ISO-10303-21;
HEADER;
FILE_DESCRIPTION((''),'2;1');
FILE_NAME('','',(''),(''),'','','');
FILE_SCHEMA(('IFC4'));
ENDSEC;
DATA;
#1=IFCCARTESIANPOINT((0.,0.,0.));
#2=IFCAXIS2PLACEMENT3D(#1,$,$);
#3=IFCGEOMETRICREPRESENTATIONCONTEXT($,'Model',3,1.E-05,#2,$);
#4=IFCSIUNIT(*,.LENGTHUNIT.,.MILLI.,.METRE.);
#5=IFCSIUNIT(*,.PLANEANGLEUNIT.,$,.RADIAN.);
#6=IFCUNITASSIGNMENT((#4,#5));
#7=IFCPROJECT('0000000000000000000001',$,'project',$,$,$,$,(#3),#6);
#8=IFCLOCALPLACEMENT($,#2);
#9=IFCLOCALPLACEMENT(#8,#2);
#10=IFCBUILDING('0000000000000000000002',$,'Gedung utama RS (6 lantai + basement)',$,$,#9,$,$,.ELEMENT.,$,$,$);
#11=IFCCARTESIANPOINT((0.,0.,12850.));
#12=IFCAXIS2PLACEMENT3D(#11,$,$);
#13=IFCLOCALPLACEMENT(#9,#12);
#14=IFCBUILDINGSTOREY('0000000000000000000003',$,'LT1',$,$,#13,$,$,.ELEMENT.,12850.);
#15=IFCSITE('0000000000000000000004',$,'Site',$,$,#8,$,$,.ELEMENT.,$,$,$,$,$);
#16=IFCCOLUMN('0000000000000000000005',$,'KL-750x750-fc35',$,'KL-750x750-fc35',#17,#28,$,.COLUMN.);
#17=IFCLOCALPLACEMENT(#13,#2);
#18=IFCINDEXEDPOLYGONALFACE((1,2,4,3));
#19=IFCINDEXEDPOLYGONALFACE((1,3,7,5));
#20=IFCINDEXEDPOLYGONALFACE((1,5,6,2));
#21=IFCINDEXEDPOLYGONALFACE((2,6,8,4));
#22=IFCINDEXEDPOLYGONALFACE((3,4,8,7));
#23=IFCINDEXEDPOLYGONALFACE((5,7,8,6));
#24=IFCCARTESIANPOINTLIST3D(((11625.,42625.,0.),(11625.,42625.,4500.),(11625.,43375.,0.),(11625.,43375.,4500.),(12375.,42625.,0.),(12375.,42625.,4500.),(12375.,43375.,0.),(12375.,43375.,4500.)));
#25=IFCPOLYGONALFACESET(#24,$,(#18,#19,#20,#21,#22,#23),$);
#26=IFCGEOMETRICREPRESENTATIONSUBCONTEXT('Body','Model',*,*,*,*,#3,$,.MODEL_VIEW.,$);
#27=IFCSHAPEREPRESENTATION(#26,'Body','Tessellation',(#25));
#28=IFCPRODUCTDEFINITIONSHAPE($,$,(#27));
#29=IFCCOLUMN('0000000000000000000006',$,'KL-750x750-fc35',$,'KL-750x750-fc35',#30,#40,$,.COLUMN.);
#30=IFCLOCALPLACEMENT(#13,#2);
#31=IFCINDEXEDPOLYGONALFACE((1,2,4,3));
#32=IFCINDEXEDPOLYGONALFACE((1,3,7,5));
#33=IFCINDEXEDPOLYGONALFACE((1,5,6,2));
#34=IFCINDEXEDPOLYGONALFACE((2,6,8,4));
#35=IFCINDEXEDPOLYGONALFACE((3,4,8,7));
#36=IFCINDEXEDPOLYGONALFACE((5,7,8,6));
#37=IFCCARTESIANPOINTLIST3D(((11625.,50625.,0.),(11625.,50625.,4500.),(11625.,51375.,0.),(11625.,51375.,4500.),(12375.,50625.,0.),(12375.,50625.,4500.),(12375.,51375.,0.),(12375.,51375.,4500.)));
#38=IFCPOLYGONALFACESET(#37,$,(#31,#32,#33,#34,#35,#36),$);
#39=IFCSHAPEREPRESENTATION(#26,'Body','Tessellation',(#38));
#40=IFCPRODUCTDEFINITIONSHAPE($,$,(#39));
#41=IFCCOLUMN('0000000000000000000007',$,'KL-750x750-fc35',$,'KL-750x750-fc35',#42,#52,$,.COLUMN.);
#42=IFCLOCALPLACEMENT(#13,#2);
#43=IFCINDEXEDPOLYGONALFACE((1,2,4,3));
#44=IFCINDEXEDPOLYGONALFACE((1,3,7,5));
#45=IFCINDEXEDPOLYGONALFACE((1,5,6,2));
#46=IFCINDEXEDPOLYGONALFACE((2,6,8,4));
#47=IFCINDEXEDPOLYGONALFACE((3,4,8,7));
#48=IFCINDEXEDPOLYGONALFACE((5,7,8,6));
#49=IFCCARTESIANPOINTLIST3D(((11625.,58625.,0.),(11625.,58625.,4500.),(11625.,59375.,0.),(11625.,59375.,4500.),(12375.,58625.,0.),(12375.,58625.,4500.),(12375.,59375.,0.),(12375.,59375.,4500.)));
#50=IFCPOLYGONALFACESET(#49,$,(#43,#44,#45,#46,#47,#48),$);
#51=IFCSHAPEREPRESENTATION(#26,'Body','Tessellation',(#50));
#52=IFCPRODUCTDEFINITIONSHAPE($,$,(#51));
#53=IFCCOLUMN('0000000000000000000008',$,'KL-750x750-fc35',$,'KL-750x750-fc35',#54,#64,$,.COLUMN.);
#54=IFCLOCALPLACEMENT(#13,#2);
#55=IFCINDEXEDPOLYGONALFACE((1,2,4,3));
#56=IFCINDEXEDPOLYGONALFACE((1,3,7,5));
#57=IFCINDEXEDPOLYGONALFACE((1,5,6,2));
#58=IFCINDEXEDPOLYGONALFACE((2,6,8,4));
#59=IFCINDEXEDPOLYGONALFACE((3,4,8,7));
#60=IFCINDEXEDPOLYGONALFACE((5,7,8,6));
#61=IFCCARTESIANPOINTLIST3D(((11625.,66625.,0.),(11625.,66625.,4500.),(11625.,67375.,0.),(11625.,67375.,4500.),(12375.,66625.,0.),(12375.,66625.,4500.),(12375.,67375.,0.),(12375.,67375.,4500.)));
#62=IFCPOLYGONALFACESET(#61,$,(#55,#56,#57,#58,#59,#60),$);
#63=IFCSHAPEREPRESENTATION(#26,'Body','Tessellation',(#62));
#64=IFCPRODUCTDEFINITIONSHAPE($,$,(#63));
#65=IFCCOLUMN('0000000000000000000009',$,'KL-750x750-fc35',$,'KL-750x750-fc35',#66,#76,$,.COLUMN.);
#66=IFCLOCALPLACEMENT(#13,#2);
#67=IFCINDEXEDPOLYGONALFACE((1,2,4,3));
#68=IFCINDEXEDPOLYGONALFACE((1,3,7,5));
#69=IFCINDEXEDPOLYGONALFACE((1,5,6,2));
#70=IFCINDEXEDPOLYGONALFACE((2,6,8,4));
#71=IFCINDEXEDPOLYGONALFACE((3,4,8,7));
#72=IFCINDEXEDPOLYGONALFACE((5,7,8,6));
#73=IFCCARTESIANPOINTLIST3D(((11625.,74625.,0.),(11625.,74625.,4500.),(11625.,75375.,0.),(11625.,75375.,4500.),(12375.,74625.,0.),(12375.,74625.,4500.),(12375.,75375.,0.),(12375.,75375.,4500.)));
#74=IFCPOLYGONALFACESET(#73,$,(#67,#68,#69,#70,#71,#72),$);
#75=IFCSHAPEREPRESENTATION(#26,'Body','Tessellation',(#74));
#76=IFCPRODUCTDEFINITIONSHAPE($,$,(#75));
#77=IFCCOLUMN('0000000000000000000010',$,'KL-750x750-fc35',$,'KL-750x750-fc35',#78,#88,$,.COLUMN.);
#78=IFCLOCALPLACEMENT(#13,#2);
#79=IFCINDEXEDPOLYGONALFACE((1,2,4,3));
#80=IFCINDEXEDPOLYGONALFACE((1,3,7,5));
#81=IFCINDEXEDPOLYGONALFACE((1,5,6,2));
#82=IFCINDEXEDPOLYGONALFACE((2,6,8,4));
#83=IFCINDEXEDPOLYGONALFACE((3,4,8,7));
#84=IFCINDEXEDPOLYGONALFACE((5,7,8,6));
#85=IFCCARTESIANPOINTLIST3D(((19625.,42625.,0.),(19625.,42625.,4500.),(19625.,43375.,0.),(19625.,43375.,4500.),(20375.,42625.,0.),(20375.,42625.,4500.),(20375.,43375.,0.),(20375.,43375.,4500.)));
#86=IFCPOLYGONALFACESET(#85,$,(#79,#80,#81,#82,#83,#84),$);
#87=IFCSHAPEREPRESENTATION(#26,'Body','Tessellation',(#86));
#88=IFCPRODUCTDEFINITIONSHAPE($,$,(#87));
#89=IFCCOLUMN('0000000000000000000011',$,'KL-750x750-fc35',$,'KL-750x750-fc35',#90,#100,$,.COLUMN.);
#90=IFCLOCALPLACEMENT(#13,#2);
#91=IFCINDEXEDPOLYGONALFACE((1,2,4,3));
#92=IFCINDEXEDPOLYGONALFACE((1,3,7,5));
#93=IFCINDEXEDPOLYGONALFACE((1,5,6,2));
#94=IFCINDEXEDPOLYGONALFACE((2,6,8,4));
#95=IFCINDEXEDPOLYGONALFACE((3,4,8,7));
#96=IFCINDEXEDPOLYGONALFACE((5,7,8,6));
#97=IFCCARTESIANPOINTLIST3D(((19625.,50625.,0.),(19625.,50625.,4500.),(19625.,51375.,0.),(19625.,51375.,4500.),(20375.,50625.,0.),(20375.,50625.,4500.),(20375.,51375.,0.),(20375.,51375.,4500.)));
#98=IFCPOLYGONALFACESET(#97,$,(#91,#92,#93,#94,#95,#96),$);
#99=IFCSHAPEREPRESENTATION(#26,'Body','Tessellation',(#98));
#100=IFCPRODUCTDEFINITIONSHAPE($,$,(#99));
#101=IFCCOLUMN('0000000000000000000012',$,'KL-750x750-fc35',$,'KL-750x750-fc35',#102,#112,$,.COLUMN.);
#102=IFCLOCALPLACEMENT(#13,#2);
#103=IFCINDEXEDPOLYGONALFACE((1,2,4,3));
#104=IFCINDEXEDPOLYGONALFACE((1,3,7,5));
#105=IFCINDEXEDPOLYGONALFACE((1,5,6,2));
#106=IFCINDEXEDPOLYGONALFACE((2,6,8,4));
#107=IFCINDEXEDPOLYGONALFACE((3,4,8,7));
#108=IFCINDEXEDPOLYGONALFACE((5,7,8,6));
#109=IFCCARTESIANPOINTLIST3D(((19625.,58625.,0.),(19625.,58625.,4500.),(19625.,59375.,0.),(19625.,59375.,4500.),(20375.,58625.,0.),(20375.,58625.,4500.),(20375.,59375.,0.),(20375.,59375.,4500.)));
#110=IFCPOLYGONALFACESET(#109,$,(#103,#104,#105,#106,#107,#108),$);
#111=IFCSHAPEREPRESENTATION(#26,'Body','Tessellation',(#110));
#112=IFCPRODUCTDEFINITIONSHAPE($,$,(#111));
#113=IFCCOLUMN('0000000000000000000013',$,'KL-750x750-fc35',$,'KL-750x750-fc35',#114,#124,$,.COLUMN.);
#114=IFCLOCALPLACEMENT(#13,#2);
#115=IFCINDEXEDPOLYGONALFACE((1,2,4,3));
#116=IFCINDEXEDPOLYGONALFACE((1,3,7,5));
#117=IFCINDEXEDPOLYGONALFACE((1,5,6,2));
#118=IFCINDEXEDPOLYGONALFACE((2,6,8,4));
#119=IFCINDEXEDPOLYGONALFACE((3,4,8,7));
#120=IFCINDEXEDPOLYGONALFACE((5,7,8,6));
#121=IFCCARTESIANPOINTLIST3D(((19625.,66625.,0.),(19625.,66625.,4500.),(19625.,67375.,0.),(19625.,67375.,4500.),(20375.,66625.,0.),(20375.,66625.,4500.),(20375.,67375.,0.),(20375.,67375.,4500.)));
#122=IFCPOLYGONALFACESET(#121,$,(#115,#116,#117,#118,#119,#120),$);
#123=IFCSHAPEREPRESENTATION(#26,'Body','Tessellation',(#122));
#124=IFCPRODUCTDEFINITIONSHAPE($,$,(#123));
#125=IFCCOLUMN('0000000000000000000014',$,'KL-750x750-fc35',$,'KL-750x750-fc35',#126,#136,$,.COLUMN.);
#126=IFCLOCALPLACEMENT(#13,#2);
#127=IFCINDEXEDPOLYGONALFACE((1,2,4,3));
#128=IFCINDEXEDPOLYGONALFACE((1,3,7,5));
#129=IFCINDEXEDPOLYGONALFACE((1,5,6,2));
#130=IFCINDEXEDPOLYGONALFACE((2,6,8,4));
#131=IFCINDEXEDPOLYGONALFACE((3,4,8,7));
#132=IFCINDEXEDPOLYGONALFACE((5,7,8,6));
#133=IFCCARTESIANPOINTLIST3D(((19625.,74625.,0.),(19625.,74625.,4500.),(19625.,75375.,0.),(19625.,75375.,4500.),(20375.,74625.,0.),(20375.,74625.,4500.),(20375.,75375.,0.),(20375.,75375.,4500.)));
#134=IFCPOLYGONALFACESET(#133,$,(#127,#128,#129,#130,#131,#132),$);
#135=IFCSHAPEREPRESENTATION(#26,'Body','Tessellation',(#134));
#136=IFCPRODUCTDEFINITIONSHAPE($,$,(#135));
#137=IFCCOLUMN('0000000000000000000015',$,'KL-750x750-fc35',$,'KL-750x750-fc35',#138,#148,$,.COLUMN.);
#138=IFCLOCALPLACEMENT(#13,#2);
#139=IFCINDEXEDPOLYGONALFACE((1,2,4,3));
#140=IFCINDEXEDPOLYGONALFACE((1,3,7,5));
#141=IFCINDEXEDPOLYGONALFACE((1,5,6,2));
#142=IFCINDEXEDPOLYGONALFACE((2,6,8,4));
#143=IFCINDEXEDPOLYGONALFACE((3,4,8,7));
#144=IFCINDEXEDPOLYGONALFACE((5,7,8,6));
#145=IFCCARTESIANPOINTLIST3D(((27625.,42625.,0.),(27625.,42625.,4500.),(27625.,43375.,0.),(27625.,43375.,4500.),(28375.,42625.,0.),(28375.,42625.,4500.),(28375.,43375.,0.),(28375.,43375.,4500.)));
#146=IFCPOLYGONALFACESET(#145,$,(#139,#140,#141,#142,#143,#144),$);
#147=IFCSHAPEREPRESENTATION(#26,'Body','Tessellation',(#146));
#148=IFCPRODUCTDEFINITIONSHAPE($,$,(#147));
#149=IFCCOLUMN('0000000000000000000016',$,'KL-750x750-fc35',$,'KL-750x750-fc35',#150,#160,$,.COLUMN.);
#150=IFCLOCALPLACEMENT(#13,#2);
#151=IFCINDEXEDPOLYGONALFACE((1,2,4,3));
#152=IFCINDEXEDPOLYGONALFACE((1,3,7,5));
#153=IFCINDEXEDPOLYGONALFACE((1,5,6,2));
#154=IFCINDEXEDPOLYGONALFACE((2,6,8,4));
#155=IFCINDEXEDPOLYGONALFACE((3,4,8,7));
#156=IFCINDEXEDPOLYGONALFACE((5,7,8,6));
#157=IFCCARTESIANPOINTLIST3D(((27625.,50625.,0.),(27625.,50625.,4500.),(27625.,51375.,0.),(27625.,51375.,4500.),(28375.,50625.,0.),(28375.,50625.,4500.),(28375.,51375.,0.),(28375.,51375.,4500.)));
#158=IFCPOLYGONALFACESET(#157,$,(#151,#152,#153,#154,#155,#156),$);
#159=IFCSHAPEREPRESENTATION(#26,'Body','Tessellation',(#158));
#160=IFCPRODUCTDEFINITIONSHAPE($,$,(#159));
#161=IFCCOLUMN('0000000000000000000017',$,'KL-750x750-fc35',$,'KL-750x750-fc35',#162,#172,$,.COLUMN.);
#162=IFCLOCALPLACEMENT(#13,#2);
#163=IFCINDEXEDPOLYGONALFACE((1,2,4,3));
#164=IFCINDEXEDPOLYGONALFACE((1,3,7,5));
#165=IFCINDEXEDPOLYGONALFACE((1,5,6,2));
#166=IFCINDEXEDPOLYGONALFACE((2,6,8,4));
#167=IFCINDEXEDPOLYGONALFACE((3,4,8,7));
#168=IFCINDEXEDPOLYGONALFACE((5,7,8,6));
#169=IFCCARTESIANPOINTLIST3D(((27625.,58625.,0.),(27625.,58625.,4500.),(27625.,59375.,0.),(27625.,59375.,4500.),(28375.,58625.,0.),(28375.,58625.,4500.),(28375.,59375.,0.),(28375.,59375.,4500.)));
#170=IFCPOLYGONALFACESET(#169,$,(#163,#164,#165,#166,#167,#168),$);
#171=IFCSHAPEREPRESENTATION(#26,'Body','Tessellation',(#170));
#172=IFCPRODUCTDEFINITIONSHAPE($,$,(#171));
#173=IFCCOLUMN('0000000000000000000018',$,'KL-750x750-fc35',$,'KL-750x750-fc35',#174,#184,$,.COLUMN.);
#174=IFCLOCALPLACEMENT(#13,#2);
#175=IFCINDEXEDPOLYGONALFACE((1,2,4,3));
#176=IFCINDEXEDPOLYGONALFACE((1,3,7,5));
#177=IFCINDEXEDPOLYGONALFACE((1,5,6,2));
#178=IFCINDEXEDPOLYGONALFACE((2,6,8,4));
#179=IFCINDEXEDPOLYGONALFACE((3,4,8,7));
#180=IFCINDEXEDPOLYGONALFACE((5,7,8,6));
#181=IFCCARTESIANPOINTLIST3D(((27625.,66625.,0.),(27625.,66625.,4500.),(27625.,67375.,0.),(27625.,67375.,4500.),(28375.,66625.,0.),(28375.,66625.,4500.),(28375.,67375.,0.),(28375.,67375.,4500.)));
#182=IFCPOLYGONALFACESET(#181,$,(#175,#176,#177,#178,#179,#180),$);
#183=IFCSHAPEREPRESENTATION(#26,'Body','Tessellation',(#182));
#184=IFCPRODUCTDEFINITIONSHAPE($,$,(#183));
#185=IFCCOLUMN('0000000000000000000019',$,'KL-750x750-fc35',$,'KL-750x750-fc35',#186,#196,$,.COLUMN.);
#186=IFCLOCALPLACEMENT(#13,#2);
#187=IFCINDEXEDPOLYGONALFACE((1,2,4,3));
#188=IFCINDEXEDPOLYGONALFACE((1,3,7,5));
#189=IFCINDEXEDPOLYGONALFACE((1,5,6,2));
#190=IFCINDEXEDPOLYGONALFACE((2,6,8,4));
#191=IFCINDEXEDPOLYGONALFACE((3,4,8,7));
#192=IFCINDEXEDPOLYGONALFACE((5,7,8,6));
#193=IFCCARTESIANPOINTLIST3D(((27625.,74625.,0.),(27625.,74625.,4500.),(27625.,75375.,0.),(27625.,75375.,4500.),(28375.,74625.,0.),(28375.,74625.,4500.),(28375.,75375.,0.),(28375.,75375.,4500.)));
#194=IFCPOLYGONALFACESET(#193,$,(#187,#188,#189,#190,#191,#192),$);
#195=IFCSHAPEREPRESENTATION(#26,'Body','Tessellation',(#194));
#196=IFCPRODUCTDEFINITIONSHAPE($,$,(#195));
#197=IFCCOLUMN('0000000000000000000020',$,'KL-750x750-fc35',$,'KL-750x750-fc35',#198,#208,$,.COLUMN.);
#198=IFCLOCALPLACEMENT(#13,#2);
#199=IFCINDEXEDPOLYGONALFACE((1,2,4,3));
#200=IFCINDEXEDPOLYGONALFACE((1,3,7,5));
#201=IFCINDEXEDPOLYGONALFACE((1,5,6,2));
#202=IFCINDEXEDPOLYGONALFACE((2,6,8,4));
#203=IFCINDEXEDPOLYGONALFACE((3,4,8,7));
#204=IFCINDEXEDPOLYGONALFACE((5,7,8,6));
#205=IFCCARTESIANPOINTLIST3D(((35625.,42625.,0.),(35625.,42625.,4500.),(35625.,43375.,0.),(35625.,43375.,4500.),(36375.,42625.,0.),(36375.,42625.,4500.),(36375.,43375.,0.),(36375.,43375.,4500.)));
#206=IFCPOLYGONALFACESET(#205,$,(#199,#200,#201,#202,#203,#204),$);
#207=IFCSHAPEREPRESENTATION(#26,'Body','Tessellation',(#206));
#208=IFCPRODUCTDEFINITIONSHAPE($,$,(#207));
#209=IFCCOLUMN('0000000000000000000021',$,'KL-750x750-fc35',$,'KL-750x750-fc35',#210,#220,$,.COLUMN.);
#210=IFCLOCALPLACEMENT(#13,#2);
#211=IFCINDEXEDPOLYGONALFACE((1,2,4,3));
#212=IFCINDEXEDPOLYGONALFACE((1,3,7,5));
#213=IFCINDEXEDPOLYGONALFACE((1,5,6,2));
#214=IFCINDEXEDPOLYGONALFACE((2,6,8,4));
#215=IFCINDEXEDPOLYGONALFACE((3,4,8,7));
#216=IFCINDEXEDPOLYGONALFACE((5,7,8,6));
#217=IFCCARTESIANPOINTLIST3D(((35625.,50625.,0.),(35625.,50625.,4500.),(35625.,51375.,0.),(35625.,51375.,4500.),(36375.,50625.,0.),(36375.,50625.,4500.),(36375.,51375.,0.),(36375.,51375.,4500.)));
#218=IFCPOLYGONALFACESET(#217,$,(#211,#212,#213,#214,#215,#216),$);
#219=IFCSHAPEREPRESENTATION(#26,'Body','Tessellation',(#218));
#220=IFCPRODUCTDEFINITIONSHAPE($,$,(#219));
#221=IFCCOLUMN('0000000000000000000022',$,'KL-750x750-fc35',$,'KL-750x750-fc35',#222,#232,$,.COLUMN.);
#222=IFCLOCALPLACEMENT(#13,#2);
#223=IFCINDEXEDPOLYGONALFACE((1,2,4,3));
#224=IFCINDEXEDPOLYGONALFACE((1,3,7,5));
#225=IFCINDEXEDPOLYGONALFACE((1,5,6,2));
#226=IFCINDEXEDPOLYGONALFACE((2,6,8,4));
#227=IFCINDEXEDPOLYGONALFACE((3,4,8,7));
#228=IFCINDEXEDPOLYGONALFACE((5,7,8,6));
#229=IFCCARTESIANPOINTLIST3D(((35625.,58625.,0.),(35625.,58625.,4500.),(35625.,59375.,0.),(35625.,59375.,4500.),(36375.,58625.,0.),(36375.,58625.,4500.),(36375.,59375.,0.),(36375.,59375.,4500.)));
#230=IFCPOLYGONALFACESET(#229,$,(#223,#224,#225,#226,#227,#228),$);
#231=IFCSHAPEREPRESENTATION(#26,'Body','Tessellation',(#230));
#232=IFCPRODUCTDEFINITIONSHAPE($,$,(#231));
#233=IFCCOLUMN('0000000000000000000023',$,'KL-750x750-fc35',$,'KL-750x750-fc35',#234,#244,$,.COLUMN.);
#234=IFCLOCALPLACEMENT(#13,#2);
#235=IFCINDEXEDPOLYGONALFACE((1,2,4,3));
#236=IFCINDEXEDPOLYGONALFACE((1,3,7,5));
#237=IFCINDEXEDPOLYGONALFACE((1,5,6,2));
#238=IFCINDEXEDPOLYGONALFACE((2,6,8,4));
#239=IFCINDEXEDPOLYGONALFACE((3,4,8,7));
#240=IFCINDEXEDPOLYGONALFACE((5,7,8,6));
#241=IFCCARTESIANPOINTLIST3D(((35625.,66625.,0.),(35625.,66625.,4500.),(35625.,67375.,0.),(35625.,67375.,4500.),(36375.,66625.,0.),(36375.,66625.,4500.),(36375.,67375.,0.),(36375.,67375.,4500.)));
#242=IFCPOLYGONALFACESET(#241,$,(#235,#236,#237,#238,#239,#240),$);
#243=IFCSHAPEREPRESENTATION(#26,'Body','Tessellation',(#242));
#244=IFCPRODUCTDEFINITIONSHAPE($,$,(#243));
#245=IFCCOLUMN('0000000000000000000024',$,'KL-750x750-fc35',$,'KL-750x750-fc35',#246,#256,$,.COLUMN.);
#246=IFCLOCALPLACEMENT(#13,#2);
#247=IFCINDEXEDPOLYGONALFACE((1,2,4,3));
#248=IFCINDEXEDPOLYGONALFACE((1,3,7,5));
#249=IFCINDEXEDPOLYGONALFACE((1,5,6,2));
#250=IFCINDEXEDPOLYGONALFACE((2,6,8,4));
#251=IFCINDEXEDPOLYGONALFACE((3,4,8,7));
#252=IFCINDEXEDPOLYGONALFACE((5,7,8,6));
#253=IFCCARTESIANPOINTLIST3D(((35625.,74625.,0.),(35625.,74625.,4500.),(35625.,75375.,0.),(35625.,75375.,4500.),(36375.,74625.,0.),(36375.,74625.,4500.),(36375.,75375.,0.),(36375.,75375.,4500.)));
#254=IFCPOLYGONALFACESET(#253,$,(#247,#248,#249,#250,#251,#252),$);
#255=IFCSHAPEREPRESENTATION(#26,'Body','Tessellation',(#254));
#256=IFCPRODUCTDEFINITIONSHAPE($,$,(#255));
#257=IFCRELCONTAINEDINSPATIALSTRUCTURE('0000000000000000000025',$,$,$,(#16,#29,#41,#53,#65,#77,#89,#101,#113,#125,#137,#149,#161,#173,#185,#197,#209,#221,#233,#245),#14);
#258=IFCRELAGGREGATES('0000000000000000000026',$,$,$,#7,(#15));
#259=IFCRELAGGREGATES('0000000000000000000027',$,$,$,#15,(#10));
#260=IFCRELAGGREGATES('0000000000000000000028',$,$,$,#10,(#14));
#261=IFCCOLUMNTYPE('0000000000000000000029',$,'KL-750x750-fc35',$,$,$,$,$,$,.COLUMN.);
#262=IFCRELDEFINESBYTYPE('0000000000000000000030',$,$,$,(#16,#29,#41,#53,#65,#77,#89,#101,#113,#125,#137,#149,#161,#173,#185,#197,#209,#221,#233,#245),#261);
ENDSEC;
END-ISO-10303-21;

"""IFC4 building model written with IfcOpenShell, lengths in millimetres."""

from ifc_helpers import new_model, si_unit, frame, origin, origin_2d, place, context, subcontext, project, spatial, rectangle, extrude, material_profile, profile_set, profile_usage, type_object, element, save


model = new_model("IFC4")

# Units and contexts
model_context = context("Model", 3, precision=1e-05, world=origin())
body_context = subcontext(model_context, "Body", "Model", "MODEL_VIEW")
ifc_project = project(units=[si_unit("LENGTHUNIT", "METRE", prefix="MILLI"), si_unit("PLANEANGLEUNIT", "RADIAN")], contexts=[model_context])

# Site, building, storey
site_placement = place(None, origin())
site = spatial("IfcSite", under=ifc_project, at=site_placement, Name="Site", CompositionType="ELEMENT")
building_placement = place(site_placement, origin())
building = spatial("IfcBuilding", under=site, at=building_placement, Name="Gedung utama RS (6 lantai + basement)", CompositionType="ELEMENT")
storey_placement = place(building_placement, frame((0.0, 0.0, 12850.0)))
storey = spatial("IfcBuildingStorey", under=building, at=storey_placement, Name="LT1", CompositionType="ELEMENT", Elevation=12850.0)

# Columns
ifc_material_profile = material_profile(None, rectangle(XDim=750.0, YDim=750.0, at=origin_2d()), Name="KL-750x750-fc35")
ifc_profile_set = profile_set([ifc_material_profile], Name="KL-750x750-fc35")
ifc_profile_usage = profile_usage(ifc_profile_set, cardinal=5)
column_type = type_object("IfcColumnType", Name="KL-750x750-fc35", PredefinedType="COLUMN", material=ifc_profile_set)
for number, where, z_axis, x_axis, name in (
    (1, (12000.0, 43000.0, 0.0), (0.0, 0.0, 1.0), (1.0, 0.0, 0.0), "KL-750x750-fc35"),
    (2, (12000.0, 51000.0, 0.0), (0.0, 0.0, 1.0), (1.0, 0.0, 0.0), "KL-750x750-fc35"),
    (3, (12000.0, 59000.0, 0.0), (0.0, 0.0, 1.0), (1.0, 0.0, 0.0), "KL-750x750-fc35"),
    (4, (12000.0, 67000.0, 0.0), (0.0, 0.0, 1.0), (1.0, 0.0, 0.0), "KL-750x750-fc35"),
    (5, (12000.0, 75000.0, 0.0), (0.0, 0.0, 1.0), (1.0, 0.0, 0.0), "KL-750x750-fc35"),
    (6, (20000.0, 43000.0, 0.0), (0.0, 0.0, 1.0), (1.0, 0.0, 0.0), "KL-750x750-fc35"),
    (7, (20000.0, 51000.0, 0.0), (0.0, 0.0, 1.0), (1.0, 0.0, 0.0), "KL-750x750-fc35"),
    (8, (20000.0, 59000.0, 0.0), (0.0, 0.0, 1.0), (1.0, 0.0, 0.0), "KL-750x750-fc35"),
    (9, (20000.0, 67000.0, 0.0), (0.0, 0.0, 1.0), (1.0, 0.0, 0.0), "KL-750x750-fc35"),
    (10, (20000.0, 75000.0, 0.0), (0.0, 0.0, 1.0), (1.0, 0.0, 0.0), "KL-750x750-fc35"),
    (11, (28000.0, 43000.0, 0.0), (0.0, 0.0, 1.0), (1.0, 0.0, 0.0), "KL-750x750-fc35"),
    (12, (28000.0, 51000.0, 0.0), (0.0, 0.0, 1.0), (1.0, 0.0, 0.0), "KL-750x750-fc35"),
    (13, (28000.0, 59000.0, 0.0), (0.0, 0.0, 1.0), (1.0, 0.0, 0.0), "KL-750x750-fc35"),
    (14, (28000.0, 67000.0, 0.0), (0.0, 0.0, 1.0), (1.0, 0.0, 0.0), "KL-750x750-fc35"),
    (15, (28000.0, 75000.0, 0.0), (0.0, 0.0, 1.0), (1.0, 0.0, 0.0), "KL-750x750-fc35"),
    (16, (36000.0, 43000.0, 0.0), (0.0, 0.0, 1.0), (1.0, 0.0, 0.0), "KL-750x750-fc35"),
    (17, (36000.0, 51000.0, 0.0), (0.0, 0.0, 1.0), (1.0, 0.0, 0.0), "KL-750x750-fc35"),
    (18, (36000.0, 59000.0, 0.0), (0.0, 0.0, 1.0), (1.0, 0.0, 0.0), "KL-750x750-fc35"),
    (19, (36000.0, 67000.0, 0.0), (0.0, 0.0, 1.0), (1.0, 0.0, 0.0), "KL-750x750-fc35"),
    (20, (36000.0, 75000.0, 0.0), (0.0, 0.0, 1.0), (1.0, 0.0, 0.0), "KL-750x750-fc35"),
):
    element("IfcColumn", number, at=place(storey_placement, frame(where, z_axis=z_axis, x_axis=x_axis)), inside=storey, type_object=column_type, material=ifc_profile_usage, Name=name, ObjectType="KL-750x750-fc35", PredefinedType="COLUMN", context=body_context, shape_type="SweptSolid", body=[
        extrude(rectangle(XDim=750.0, YDim=750.0, at=origin_2d()), origin(), (0.0, 0.0, 1.0), 4500.0),
    ])

save(model, "model.ifc")
